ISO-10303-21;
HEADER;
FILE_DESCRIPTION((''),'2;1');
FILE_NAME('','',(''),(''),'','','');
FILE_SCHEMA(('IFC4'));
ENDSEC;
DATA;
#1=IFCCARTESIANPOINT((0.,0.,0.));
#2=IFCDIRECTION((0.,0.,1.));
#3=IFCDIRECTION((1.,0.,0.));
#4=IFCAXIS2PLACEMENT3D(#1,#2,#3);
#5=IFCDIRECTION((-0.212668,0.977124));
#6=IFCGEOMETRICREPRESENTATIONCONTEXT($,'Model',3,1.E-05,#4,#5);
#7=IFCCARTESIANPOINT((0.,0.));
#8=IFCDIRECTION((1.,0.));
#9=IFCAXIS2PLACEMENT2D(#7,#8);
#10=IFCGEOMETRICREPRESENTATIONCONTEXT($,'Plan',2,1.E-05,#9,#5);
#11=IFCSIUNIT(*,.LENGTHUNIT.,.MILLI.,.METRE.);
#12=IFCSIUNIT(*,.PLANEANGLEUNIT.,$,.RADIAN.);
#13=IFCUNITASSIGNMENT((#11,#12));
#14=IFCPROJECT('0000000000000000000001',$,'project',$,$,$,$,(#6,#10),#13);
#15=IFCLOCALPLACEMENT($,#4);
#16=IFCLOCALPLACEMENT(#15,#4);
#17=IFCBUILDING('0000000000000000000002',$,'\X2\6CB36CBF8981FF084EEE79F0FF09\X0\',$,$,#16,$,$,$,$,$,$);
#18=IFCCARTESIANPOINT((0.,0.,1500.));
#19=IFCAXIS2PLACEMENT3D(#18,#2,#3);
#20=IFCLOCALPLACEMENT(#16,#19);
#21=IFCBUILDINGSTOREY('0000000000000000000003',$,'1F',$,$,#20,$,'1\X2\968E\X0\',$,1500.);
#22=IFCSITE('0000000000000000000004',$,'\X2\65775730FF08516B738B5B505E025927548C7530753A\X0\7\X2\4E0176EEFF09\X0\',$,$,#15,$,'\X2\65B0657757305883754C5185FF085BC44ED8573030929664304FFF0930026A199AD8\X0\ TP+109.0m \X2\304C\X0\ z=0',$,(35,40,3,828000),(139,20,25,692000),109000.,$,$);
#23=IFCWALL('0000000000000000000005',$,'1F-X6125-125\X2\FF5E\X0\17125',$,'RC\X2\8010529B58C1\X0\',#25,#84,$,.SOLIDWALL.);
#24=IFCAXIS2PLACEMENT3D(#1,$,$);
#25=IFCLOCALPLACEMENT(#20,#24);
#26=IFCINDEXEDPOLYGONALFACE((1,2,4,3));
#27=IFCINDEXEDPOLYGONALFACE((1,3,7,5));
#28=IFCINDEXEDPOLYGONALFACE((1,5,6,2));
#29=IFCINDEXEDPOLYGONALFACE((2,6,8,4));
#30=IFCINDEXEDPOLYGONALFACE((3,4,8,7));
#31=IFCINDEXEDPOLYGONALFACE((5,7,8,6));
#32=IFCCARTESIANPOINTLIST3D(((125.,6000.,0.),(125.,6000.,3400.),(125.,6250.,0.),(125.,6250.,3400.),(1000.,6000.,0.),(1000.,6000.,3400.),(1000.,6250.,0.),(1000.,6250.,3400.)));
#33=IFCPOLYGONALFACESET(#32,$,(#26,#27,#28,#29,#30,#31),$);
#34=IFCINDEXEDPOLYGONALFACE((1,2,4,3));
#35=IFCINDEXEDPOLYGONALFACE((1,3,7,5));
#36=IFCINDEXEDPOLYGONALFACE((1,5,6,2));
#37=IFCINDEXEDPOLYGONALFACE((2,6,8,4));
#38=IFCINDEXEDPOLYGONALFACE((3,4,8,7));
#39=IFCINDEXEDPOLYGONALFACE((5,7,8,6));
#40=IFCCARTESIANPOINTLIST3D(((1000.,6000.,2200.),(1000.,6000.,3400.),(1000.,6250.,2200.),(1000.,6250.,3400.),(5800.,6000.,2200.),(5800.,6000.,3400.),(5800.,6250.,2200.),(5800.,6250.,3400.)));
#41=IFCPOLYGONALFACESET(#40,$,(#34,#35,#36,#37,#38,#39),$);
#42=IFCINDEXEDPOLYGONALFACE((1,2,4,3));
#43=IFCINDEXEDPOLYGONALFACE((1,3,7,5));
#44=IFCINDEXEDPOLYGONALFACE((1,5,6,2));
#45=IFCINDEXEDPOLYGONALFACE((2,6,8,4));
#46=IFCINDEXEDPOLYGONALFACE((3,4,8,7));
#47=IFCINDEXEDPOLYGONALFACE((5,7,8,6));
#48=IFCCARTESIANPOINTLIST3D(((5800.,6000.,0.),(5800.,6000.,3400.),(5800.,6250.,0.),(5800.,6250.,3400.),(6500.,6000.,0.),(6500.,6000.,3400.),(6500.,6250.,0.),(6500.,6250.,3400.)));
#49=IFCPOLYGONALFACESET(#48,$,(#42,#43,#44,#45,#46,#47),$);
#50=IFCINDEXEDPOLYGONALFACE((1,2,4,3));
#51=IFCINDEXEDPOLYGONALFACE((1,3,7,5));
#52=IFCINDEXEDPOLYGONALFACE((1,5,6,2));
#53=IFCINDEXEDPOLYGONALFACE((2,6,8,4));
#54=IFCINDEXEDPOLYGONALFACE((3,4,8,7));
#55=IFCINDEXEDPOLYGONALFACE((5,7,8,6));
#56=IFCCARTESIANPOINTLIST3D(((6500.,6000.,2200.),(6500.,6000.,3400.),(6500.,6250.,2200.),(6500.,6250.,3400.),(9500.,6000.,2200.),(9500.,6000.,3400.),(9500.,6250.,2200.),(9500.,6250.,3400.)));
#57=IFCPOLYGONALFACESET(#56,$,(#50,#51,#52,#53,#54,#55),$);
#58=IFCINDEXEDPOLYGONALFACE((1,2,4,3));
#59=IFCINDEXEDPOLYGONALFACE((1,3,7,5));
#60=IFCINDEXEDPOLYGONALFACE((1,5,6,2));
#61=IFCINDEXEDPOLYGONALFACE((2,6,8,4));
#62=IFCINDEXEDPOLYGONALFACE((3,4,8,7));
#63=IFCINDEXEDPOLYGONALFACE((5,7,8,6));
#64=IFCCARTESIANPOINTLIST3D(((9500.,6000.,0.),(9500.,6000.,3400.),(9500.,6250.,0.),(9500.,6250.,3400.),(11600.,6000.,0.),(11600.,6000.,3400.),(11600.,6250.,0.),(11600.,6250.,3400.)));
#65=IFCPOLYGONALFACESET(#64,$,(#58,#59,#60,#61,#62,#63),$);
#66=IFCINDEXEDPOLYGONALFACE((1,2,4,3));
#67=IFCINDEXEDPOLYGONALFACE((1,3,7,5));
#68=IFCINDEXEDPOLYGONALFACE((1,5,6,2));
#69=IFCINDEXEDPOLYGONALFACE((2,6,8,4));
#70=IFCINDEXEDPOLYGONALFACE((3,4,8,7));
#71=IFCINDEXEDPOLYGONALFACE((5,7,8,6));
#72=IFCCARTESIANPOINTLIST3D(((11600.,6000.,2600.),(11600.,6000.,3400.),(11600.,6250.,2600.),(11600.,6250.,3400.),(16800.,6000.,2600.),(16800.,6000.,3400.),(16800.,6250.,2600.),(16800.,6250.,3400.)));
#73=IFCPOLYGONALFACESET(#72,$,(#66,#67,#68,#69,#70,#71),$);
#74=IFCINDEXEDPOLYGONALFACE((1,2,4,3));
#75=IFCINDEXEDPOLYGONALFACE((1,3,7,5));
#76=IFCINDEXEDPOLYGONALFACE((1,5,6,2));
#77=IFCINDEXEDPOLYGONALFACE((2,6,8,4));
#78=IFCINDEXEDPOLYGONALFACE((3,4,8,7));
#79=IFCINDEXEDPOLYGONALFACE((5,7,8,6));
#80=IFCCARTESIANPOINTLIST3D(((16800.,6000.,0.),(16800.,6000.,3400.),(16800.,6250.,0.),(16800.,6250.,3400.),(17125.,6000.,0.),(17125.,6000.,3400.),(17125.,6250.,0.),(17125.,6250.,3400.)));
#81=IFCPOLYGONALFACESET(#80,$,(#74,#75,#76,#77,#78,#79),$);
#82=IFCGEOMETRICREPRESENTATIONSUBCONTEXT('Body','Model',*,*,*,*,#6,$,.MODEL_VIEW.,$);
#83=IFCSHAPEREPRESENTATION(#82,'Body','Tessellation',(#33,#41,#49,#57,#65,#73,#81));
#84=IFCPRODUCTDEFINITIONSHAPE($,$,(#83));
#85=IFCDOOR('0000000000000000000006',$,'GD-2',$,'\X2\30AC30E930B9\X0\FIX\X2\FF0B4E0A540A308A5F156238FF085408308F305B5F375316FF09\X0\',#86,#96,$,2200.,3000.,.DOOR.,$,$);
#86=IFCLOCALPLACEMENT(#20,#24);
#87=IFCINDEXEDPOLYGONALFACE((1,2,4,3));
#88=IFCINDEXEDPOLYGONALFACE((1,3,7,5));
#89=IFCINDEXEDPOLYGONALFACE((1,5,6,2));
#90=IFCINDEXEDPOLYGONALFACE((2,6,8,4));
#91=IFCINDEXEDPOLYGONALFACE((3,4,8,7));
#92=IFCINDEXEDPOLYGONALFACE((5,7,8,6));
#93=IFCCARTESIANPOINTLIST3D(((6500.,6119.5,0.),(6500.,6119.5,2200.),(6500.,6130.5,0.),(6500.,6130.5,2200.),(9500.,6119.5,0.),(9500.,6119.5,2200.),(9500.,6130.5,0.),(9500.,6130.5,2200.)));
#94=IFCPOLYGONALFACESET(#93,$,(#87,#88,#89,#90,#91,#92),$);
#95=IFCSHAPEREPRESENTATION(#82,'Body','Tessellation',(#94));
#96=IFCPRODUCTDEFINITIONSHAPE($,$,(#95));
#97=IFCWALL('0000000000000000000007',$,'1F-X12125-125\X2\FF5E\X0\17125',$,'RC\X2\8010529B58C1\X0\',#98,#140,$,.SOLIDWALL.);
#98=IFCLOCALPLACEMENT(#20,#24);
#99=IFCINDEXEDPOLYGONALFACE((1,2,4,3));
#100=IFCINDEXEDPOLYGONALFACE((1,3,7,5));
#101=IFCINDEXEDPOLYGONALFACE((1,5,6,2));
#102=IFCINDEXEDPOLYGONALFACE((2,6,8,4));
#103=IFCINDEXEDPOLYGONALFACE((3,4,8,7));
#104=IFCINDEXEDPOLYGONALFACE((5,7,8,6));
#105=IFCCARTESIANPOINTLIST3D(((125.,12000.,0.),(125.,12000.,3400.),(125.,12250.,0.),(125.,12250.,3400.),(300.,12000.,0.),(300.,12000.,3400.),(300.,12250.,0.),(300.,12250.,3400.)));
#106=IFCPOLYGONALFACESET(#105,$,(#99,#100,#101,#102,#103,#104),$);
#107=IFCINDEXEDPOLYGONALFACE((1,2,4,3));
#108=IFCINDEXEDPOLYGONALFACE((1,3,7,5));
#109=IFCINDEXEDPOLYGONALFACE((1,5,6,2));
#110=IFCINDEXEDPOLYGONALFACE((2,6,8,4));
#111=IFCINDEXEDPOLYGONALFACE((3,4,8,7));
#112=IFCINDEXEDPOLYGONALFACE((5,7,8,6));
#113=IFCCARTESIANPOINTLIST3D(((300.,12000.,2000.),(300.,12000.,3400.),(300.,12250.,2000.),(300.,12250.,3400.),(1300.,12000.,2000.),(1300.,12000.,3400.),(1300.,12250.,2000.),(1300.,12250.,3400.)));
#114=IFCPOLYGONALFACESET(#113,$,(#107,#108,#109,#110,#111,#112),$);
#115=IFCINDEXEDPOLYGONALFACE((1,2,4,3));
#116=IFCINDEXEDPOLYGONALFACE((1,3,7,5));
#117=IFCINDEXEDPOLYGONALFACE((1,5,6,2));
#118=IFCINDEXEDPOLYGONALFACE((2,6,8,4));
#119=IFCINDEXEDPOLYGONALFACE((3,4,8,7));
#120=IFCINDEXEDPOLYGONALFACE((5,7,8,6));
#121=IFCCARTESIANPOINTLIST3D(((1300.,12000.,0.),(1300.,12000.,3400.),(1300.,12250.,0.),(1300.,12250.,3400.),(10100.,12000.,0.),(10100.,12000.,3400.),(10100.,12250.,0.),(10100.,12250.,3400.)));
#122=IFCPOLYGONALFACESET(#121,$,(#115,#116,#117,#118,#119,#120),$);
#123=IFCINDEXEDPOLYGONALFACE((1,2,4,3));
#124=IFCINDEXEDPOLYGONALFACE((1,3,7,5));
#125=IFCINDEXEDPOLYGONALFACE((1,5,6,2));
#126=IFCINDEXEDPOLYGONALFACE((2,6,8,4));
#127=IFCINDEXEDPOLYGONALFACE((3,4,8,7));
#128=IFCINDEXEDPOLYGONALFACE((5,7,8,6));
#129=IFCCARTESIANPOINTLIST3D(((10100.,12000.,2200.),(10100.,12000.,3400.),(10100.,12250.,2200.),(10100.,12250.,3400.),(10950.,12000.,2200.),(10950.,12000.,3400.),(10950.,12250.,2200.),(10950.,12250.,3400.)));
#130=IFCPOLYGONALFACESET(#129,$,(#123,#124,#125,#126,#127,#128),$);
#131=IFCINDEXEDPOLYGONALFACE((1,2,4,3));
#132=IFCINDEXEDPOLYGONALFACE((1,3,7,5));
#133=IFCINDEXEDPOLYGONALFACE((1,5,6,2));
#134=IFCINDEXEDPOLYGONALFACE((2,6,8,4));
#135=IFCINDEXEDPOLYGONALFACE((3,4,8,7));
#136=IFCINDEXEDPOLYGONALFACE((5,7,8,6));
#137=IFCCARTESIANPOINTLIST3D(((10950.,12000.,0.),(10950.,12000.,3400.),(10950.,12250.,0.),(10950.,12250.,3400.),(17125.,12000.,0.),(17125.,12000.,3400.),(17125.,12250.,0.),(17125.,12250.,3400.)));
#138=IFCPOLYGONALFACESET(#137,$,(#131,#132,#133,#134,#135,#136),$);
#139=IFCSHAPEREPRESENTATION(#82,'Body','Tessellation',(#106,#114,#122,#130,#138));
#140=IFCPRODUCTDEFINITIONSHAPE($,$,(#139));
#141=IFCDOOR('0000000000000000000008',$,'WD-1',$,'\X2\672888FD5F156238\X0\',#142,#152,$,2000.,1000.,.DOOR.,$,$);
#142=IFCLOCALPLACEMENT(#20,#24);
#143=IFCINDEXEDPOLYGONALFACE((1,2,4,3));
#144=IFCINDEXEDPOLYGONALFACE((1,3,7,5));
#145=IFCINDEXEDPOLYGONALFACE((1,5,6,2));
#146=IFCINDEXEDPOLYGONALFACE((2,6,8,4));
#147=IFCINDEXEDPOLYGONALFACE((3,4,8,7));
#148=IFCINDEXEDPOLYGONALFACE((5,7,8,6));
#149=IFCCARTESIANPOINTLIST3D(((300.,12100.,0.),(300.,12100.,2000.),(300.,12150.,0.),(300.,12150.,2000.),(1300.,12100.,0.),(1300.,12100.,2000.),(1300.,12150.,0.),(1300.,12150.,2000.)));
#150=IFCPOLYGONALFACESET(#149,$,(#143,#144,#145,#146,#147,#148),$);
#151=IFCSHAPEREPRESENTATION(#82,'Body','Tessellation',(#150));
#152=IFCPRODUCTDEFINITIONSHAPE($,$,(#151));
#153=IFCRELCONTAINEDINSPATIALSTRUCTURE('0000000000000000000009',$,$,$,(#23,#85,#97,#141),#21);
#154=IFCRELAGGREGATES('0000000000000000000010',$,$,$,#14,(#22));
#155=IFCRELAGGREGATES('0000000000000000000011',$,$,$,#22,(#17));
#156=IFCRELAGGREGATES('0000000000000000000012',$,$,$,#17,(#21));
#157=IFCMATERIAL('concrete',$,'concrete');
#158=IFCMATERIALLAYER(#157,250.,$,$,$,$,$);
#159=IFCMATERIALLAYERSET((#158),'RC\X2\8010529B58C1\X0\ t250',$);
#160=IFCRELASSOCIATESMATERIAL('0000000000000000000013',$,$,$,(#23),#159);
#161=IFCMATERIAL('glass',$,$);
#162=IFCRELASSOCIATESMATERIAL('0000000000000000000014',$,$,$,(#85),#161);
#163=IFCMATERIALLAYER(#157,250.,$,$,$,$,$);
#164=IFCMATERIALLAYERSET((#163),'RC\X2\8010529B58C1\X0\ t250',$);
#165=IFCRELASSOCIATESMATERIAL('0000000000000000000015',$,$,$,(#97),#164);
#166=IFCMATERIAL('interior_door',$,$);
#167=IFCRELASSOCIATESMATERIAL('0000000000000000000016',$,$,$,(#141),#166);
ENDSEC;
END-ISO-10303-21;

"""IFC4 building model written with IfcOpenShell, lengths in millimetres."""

from ifc_helpers import new_model, si_unit, direction, frame, frame_2d, origin, origin_with_axes, origin_2d_with_axis, place, context, subcontext, project, spatial, rectangle, extrude, material, layer, layer_set, layer_usage, element, fill, save


model = new_model("IFC4")

# Units and contexts
model_context = context("Model", 3, precision=1e-05, world=origin_with_axes(), true_north=direction((-0.212668, 0.977124)))
plan_context = context("Plan", 2, precision=1e-05, world=origin_2d_with_axis(), true_north=direction((-0.212668, 0.977124)))
body_context = subcontext(model_context, "Body", "Model", "MODEL_VIEW")
ifc_project = project(units=[si_unit("LENGTHUNIT", "METRE", prefix="MILLI"), si_unit("PLANEANGLEUNIT", "RADIAN")], contexts=[model_context, plan_context])

# Site, building, storey
site_placement = place(None, origin_with_axes())
site = spatial("IfcSite", under=ifc_project, at=site_placement, Name="敷地（八王子市大和田町7丁目）", LongName="新敷地境界内（寄付地を除く）。標高 TP+109.0m が z=0", RefLatitude=(35, 40, 3, 828000), RefLongitude=(139, 20, 25, 692000), RefElevation=109000.0)
building_placement = place(site_placement, origin_with_axes())
building = spatial("IfcBuilding", under=site, at=building_placement, Name="河沿要（仮称）")
storey_placement = place(building_placement, frame((0.0, 0.0, 1500.0), z_axis=(0.0, 0.0, 1.0), x_axis=(1.0, 0.0, 0.0)))
storey = spatial("IfcBuildingStorey", under=building, at=storey_placement, Name="1F", LongName="1階", Elevation=1500.0)

# Shared definitions
ifc_material_1 = material(Name="concrete", Category="concrete")
ifc_material_2 = material(Name="glass")

# Shared definitions
ifc_material_3 = material(Name="interior_door")

# Walls, openings, doors
ifc_layer_1 = layer(ifc_material_1, 250.0)
ifc_layer_set_1 = layer_set([ifc_layer_1], Name="RC耐力壁 t250")
ifc_layer_usage_1 = layer_usage(ifc_layer_set_1, "AXIS2", "POSITIVE", 0.0)
wall_1_placement = place(storey_placement, origin_with_axes())
wall_1 = element("IfcWall", 1, at=wall_1_placement, inside=storey, material=ifc_layer_usage_1, Name="1F-X6125-125～17125", ObjectType="RC耐力壁", PredefinedType="SOLIDWALL", context=body_context, shape_type="SweptSolid", body=[
    extrude(rectangle(XDim=875.0, YDim=250.0, at=frame_2d((562.5, 6125.0))), origin(), (0.0, 0.0, 1.0), 3400.0),
    extrude(rectangle(XDim=4800.0, YDim=250.0, at=frame_2d((3400.0, 6125.0))), frame((0.0, 0.0, 2200.0)), (0.0, 0.0, 1.0), 1200.0),
    extrude(rectangle(XDim=700.0, YDim=250.0, at=frame_2d((6150.0, 6125.0))), origin(), (0.0, 0.0, 1.0), 3400.0),
    extrude(rectangle(XDim=3000.0, YDim=250.0, at=frame_2d((8000.0, 6125.0))), frame((0.0, 0.0, 2200.0)), (0.0, 0.0, 1.0), 1200.0),
    extrude(rectangle(XDim=2100.0, YDim=250.0, at=frame_2d((10550.0, 6125.0))), origin(), (0.0, 0.0, 1.0), 3400.0),
    extrude(rectangle(XDim=5200.0, YDim=250.0, at=frame_2d((14200.0, 6125.0))), frame((0.0, 0.0, 2600.0)), (0.0, 0.0, 1.0), 800.0),
    extrude(rectangle(XDim=325.0, YDim=250.0, at=frame_2d((16962.5, 6125.0))), origin(), (0.0, 0.0, 1.0), 3400.0),
])
opening_1_placement = place(storey_placement, origin_with_axes())
element("IfcOpeningElement", 2, at=opening_1_placement, inside=storey, cuts=wall_1, PredefinedType="OPENING", context=body_context, shape_type="SweptSolid", body=[
    extrude(rectangle(XDim=4800.0, YDim=300.0, at=frame_2d((3400.0, 6125.0))), origin(), (0.0, 0.0, 1.0), 2200.0),
])
opening_2_placement = place(storey_placement, origin_with_axes())
opening_2 = element("IfcOpeningElement", 3, at=opening_2_placement, inside=storey, cuts=wall_1, PredefinedType="OPENING", context=body_context, shape_type="SweptSolid", body=[
    extrude(rectangle(XDim=3000.0, YDim=300.0, at=frame_2d((8000.0, 6125.0))), origin(), (0.0, 0.0, 1.0), 2200.0),
])
opening_3_placement = place(storey_placement, origin_with_axes())
element("IfcOpeningElement", 4, at=opening_3_placement, inside=storey, cuts=wall_1, PredefinedType="OPENING", context=body_context, shape_type="SweptSolid", body=[
    extrude(rectangle(XDim=5200.0, YDim=300.0, at=frame_2d((14200.0, 6125.0))), origin(), (0.0, 0.0, 1.0), 2600.0),
])
door_1_placement = place(storey_placement, origin_with_axes())
door_1 = element("IfcDoor", 5, at=door_1_placement, inside=storey, material=ifc_material_2, Name="GD-2", ObjectType="ガラスFIX＋上吊り引戸（合わせ強化）", OverallHeight=2200.0, OverallWidth=3000.0, PredefinedType="DOOR", context=body_context, shape_type="SweptSolid", body=[
    extrude(rectangle(XDim=3000.0, YDim=11.0, at=frame_2d((8000.0, 6125.0))), origin(), (0.0, 0.0, 1.0), 2200.0),
])
fill(opening_2, door_1)
ifc_layer_2 = layer(ifc_material_1, 250.0)
ifc_layer_set_2 = layer_set([ifc_layer_2], Name="RC耐力壁 t250")
ifc_layer_usage_2 = layer_usage(ifc_layer_set_2, "AXIS2", "POSITIVE", 0.0)
wall_2_placement = place(storey_placement, origin_with_axes())
wall_2 = element("IfcWall", 6, at=wall_2_placement, inside=storey, material=ifc_layer_usage_2, Name="1F-X12125-125～17125", ObjectType="RC耐力壁", PredefinedType="SOLIDWALL", context=body_context, shape_type="SweptSolid", body=[
    extrude(rectangle(XDim=175.0, YDim=250.0, at=frame_2d((212.5, 12125.0))), origin(), (0.0, 0.0, 1.0), 3400.0),
    extrude(rectangle(XDim=1000.0, YDim=250.0, at=frame_2d((800.0, 12125.0))), frame((0.0, 0.0, 2000.0)), (0.0, 0.0, 1.0), 1400.0),
    extrude(rectangle(XDim=8800.0, YDim=250.0, at=frame_2d((5700.0, 12125.0))), origin(), (0.0, 0.0, 1.0), 3400.0),
    extrude(rectangle(XDim=850.0, YDim=250.0, at=frame_2d((10525.0, 12125.0))), frame((0.0, 0.0, 2200.0)), (0.0, 0.0, 1.0), 1200.0),
    extrude(rectangle(XDim=6175.0, YDim=250.0, at=frame_2d((14037.5, 12125.0))), origin(), (0.0, 0.0, 1.0), 3400.0),
])
opening_4_placement = place(storey_placement, origin_with_axes())
opening_4 = element("IfcOpeningElement", 7, at=opening_4_placement, inside=storey, cuts=wall_2, PredefinedType="OPENING", context=body_context, shape_type="SweptSolid", body=[
    extrude(rectangle(XDim=1000.0, YDim=300.0, at=frame_2d((800.0, 12125.0))), origin(), (0.0, 0.0, 1.0), 2000.0),
])
opening_5_placement = place(storey_placement, origin_with_axes())
element("IfcOpeningElement", 8, at=opening_5_placement, inside=storey, cuts=wall_2, PredefinedType="OPENING", context=body_context, shape_type="SweptSolid", body=[
    extrude(rectangle(XDim=850.0, YDim=300.0, at=frame_2d((10525.0, 12125.0))), origin(), (0.0, 0.0, 1.0), 2200.0),
])
door_2_placement = place(storey_placement, origin_with_axes())
door_2 = element("IfcDoor", 9, at=door_2_placement, inside=storey, material=ifc_material_3, Name="WD-1", ObjectType="木製引戸", OverallHeight=2000.0, OverallWidth=1000.0, PredefinedType="DOOR", context=body_context, shape_type="SweptSolid", body=[
    extrude(rectangle(XDim=1000.0, YDim=50.0, at=frame_2d((800.0, 12125.0))), origin(), (0.0, 0.0, 1.0), 2000.0),
])
fill(opening_4, door_2)

save(model, "model.ifc")
